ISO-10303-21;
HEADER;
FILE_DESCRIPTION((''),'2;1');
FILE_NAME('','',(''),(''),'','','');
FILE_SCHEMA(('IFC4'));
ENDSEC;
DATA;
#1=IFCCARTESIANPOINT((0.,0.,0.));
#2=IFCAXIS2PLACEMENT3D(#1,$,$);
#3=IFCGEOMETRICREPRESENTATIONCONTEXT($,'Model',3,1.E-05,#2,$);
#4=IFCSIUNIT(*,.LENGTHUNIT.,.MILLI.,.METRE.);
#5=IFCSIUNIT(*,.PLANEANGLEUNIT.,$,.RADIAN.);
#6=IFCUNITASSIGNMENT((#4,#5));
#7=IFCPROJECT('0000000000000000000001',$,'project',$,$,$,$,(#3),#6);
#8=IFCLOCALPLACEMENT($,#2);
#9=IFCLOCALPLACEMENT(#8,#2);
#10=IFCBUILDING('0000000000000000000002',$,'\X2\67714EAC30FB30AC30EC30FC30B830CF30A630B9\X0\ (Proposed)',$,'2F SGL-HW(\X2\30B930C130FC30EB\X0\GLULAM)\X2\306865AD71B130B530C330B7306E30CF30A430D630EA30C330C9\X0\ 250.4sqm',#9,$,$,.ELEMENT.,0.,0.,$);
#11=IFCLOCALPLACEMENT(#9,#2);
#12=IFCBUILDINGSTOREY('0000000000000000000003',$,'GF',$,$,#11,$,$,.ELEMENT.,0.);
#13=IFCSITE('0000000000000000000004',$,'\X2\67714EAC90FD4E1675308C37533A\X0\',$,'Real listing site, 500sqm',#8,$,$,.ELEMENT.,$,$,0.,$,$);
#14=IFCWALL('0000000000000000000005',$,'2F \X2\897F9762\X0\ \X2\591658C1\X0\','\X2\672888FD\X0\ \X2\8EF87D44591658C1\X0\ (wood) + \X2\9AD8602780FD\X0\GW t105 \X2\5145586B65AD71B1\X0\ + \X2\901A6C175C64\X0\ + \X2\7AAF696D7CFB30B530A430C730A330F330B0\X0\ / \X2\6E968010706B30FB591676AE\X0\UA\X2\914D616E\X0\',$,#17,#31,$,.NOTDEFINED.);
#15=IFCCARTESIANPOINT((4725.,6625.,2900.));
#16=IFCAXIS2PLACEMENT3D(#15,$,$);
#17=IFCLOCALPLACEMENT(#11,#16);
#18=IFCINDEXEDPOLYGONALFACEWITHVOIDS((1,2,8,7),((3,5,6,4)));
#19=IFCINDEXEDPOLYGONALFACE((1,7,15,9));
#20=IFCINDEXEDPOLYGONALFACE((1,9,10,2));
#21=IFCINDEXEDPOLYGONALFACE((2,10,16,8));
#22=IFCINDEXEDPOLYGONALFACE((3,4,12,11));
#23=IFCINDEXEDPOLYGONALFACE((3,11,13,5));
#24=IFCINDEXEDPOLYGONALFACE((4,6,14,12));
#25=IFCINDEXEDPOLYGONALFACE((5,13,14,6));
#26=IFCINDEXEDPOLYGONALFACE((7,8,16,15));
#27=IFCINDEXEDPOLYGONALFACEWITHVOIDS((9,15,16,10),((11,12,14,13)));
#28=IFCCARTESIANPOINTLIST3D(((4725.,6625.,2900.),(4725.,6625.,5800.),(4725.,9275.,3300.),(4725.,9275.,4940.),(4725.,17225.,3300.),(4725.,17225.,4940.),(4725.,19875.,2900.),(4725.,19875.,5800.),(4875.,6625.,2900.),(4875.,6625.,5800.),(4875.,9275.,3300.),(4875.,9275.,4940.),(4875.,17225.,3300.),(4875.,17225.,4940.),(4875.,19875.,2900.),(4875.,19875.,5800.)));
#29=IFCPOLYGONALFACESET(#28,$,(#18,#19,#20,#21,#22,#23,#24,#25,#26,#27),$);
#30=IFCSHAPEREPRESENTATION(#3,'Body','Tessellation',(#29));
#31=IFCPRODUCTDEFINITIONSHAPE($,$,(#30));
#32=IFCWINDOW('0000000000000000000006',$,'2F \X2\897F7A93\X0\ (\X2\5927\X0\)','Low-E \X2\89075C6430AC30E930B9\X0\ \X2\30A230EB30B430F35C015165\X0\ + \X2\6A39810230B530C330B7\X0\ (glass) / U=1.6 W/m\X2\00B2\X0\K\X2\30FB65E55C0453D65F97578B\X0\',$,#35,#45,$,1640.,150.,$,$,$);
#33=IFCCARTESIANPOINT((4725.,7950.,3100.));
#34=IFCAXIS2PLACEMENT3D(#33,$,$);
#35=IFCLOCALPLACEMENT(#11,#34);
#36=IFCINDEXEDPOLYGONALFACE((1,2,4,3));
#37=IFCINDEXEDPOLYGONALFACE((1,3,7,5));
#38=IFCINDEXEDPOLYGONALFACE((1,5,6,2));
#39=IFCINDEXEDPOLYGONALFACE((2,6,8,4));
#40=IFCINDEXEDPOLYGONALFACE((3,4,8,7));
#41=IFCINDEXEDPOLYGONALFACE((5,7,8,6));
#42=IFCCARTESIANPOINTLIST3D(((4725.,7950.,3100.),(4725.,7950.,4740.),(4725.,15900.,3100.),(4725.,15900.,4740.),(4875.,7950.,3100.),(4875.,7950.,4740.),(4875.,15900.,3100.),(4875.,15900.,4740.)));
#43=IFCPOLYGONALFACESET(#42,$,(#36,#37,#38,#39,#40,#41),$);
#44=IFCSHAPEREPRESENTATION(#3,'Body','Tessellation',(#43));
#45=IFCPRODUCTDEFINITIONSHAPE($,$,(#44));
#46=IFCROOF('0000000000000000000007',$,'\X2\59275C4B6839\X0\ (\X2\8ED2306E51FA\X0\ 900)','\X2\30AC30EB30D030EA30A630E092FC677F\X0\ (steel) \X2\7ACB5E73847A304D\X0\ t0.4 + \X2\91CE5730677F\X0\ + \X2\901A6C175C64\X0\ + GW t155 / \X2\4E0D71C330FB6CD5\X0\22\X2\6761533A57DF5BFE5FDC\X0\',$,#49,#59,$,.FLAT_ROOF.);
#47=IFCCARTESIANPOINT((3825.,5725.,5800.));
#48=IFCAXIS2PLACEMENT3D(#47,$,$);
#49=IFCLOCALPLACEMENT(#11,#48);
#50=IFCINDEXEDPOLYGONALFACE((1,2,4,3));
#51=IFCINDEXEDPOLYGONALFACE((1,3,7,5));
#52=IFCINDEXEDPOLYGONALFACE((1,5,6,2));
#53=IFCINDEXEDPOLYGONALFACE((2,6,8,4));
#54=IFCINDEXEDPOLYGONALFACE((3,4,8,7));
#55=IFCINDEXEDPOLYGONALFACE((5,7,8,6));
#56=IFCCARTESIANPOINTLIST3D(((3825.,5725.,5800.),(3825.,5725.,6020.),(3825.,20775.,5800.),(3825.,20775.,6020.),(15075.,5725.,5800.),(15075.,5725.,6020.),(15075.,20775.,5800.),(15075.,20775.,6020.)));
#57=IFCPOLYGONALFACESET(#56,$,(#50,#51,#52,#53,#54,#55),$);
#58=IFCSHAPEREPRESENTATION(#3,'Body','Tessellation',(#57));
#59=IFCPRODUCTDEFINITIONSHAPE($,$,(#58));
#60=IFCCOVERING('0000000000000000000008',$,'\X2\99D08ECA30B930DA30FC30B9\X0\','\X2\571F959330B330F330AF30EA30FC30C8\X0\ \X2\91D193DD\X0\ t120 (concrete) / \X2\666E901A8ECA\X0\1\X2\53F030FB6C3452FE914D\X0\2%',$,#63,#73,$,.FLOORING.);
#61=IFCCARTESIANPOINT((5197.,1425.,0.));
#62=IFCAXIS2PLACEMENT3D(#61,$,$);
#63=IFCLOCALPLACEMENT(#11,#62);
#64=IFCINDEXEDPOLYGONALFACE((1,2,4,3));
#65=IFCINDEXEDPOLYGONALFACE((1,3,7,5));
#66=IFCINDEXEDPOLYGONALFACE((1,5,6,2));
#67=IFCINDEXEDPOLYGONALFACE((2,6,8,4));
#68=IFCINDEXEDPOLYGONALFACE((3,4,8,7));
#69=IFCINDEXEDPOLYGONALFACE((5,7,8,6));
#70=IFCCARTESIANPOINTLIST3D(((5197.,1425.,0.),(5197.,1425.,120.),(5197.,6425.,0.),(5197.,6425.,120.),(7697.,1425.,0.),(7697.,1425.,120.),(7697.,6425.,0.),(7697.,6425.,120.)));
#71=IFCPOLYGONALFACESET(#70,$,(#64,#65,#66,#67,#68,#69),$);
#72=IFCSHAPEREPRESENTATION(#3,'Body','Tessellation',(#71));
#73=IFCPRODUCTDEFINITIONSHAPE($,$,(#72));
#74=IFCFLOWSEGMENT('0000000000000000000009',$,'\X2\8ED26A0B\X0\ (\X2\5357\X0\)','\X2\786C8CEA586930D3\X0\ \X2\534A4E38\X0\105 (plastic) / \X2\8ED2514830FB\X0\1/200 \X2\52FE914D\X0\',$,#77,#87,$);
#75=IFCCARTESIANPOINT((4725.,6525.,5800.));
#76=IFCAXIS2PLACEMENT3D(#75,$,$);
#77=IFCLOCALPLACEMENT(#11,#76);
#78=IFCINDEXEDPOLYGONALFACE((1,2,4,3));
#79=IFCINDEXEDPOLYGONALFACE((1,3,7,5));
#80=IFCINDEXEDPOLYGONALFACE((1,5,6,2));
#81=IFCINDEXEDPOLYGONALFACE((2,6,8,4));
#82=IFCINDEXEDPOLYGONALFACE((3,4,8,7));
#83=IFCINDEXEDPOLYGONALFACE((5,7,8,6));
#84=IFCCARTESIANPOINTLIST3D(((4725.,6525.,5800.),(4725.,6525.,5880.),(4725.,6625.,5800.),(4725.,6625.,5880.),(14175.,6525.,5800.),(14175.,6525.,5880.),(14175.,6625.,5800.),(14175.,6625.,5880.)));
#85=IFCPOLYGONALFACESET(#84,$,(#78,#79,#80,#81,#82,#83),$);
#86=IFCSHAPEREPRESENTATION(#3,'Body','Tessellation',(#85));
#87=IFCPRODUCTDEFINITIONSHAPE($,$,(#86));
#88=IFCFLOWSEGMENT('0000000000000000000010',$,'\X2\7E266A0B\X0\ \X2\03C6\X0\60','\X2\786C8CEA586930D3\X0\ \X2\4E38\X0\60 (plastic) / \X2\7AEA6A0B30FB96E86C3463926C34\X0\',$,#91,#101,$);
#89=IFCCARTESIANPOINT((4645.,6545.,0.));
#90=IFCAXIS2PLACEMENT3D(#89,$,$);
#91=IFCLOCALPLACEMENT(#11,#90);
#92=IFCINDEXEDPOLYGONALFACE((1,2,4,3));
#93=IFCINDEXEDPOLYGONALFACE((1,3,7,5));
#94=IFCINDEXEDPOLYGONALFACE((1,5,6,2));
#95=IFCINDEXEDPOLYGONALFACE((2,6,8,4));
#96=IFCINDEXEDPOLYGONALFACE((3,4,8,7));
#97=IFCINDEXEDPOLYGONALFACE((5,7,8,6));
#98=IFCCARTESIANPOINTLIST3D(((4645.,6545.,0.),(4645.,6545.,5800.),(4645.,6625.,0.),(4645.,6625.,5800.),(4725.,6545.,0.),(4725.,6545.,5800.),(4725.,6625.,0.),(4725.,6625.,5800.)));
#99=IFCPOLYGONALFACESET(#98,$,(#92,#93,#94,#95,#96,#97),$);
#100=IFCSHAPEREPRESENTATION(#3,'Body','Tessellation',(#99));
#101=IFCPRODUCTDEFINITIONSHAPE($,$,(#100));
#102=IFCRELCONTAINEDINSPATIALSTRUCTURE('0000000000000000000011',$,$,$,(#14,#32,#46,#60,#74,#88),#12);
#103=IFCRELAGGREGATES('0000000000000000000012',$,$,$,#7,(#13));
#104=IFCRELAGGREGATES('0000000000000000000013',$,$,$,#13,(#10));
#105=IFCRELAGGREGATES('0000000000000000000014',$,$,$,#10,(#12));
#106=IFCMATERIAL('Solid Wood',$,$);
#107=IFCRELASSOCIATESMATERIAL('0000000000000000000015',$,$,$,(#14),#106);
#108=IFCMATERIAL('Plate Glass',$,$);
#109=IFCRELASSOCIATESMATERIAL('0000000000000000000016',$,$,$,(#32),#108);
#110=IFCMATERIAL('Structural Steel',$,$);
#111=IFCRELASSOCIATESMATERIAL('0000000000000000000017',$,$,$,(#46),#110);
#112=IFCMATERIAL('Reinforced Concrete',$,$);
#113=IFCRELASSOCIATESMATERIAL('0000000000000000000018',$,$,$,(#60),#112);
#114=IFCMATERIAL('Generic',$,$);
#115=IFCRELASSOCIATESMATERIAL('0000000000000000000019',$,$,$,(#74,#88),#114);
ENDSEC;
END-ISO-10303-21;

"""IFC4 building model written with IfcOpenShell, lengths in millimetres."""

from ifc_helpers import new_model, si_unit, frame, frame_2d, origin, place, context, project, spatial, rectangle, extrude, material, element, fill, save


model = new_model("IFC4")

# Units and contexts
model_context = context("Model", 3, precision=1e-05, world=origin())
ifc_project = project(units=[si_unit("LENGTHUNIT", "METRE", prefix="MILLI"), si_unit("PLANEANGLEUNIT", "RADIAN")], contexts=[model_context])

# Site, building, storey
site_placement = place(None, origin())
site = spatial("IfcSite", under=ifc_project, at=site_placement, Name="東京都世田谷区", ObjectType="Real listing site, 500sqm", CompositionType="ELEMENT", RefElevation=0.0)
building_placement = place(site_placement, origin())
building = spatial("IfcBuilding", under=site, at=building_placement, Name="東京・ガレージハウス (Proposed)", ObjectType="2F SGL-HW(スチールGLULAM)と断熱サッシのハイブリッド 250.4sqm", CompositionType="ELEMENT", ElevationOfRefHeight=0.0, ElevationOfTerrain=0.0)
storey_placement = place(building_placement, origin())
storey = spatial("IfcBuildingStorey", under=building, at=storey_placement, Name="GF", CompositionType="ELEMENT", Elevation=0.0)

# Shared definitions
ifc_material_1 = material(Name="Solid Wood")

# Shared definitions
ifc_material_2 = material(Name="Reinforced Concrete")

# Shared definitions
ifc_material_3 = material(Name="Plate Glass")

# Wall, opening, window
wall_1_placement = place(storey_placement, frame((4725.0, 6625.0, 2900.0)))
wall_1 = element("IfcWall", 1, at=wall_1_placement, inside=storey, material=ifc_material_1, Name="2F 西面 外壁", Description="木製 軸組外壁 (wood) + 高性能GW t105 充填断熱 + 通気層 + 窯業系サイディング / 準耐火・外皮UA配慮", PredefinedType="NOTDEFINED", context=model_context, shape_type="SweptSolid", body=[
    extrude(rectangle(XDim=150.0, YDim=13250.0, at=frame_2d((75.0, 6625.0))), frame((4725.0, 6625.0, 2900.0)), (0.0, 0.0, 1.0), 2900.0),
])
opening_1_placement = place(storey_placement, frame((4725.0, 7950.0, 3100.0)))
opening_1 = element("IfcOpeningElement", 2, at=opening_1_placement, cuts=wall_1, PredefinedType="NOTDEFINED", context=model_context, shape_type="SweptSolid", body=[
    extrude(rectangle(XDim=150.0, YDim=7950.0, at=frame_2d((75.0, 3975.0))), frame((4725.0, 7950.0, 3100.0)), (0.0, 0.0, 1.0), 1640.0),
])
window_1_placement = place(storey_placement, frame((4725.0, 7950.0, 3100.0)))
window_1 = element("IfcWindow", 3, at=window_1_placement, inside=storey, material=ifc_material_3, Name="2F 西窓 (大)", Description="Low-E 複層ガラス アルゴン封入 + 樹脂サッシ (glass) / U=1.6 W/m²K・日射取得型", OverallHeight=1640.0, OverallWidth=150.0, context=model_context, shape_type="SweptSolid", body=[
    extrude(rectangle(XDim=150.0, YDim=7950.0, at=frame_2d((75.0, 3975.0))), frame((4725.0, 7950.0, 3100.0)), (0.0, 0.0, 1.0), 1640.0),
])
fill(opening_1, window_1)

# Roof
ifc_material_4 = material(Name="Structural Steel")
roof_placement = place(storey_placement, frame((3825.0, 5725.0, 5800.0)))
element("IfcRoof", 4, at=roof_placement, inside=storey, material=ifc_material_4, Name="大屋根 (軒の出 900)", Description="ガルバリウム鋼板 (steel) 立平葺き t0.4 + 野地板 + 通気層 + GW t155 / 不燃・法22条区域対応", PredefinedType="FLAT_ROOF", context=model_context, shape_type="SweptSolid", body=[
    extrude(rectangle(XDim=11250.0, YDim=15050.0, at=frame_2d((5625.0, 7525.0))), frame((3825.0, 5725.0, 5800.0)), (0.0, 0.0, 1.0), 220.0),
])

# Covering
covering_placement = place(storey_placement, frame((5197.0, 1425.0, 0.0)))
element("IfcCovering", 5, at=covering_placement, inside=storey, material=ifc_material_2, Name="駐車スペース", Description="土間コンクリート 金鏝 t120 (concrete) / 普通車1台・水勾配2%", PredefinedType="FLOORING", context=model_context, shape_type="SweptSolid", body=[
    extrude(rectangle(XDim=2500.0, YDim=5000.0, at=frame_2d((1250.0, 2500.0))), frame((5197.0, 1425.0, 0.0)), (0.0, 0.0, 1.0), 120.0),
])

# Flow segments
ifc_material_5 = material(Name="Generic")
flow_segment_1_placement = place(storey_placement, frame((4725.0, 6525.0, 5800.0)))
element("IfcFlowSegment", 6, at=flow_segment_1_placement, inside=storey, material=ifc_material_5, Name="軒樋 (南)", Description="硬質塩ビ 半丸105 (plastic) / 軒先・1/200 勾配", context=model_context, shape_type="SweptSolid", body=[
    extrude(rectangle(XDim=9450.0, YDim=100.0, at=frame_2d((4725.0, 50.0))), frame((4725.0, 6525.0, 5800.0)), (0.0, 0.0, 1.0), 80.0),
])
flow_segment_2_placement = place(storey_placement, frame((4645.0, 6545.0, 0.0)))
element("IfcFlowSegment", 7, at=flow_segment_2_placement, inside=storey, material=ifc_material_5, Name="縦樋 φ60", Description="硬質塩ビ 丸60 (plastic) / 竪樋・雨水排水", context=model_context, shape_type="SweptSolid", body=[
    extrude(rectangle(XDim=80.0, YDim=80.0, at=frame_2d((40.0, 40.0))), frame((4645.0, 6545.0, 0.0)), (0.0, 0.0, 1.0), 5800.0),
])

save(model, "model.ifc")
